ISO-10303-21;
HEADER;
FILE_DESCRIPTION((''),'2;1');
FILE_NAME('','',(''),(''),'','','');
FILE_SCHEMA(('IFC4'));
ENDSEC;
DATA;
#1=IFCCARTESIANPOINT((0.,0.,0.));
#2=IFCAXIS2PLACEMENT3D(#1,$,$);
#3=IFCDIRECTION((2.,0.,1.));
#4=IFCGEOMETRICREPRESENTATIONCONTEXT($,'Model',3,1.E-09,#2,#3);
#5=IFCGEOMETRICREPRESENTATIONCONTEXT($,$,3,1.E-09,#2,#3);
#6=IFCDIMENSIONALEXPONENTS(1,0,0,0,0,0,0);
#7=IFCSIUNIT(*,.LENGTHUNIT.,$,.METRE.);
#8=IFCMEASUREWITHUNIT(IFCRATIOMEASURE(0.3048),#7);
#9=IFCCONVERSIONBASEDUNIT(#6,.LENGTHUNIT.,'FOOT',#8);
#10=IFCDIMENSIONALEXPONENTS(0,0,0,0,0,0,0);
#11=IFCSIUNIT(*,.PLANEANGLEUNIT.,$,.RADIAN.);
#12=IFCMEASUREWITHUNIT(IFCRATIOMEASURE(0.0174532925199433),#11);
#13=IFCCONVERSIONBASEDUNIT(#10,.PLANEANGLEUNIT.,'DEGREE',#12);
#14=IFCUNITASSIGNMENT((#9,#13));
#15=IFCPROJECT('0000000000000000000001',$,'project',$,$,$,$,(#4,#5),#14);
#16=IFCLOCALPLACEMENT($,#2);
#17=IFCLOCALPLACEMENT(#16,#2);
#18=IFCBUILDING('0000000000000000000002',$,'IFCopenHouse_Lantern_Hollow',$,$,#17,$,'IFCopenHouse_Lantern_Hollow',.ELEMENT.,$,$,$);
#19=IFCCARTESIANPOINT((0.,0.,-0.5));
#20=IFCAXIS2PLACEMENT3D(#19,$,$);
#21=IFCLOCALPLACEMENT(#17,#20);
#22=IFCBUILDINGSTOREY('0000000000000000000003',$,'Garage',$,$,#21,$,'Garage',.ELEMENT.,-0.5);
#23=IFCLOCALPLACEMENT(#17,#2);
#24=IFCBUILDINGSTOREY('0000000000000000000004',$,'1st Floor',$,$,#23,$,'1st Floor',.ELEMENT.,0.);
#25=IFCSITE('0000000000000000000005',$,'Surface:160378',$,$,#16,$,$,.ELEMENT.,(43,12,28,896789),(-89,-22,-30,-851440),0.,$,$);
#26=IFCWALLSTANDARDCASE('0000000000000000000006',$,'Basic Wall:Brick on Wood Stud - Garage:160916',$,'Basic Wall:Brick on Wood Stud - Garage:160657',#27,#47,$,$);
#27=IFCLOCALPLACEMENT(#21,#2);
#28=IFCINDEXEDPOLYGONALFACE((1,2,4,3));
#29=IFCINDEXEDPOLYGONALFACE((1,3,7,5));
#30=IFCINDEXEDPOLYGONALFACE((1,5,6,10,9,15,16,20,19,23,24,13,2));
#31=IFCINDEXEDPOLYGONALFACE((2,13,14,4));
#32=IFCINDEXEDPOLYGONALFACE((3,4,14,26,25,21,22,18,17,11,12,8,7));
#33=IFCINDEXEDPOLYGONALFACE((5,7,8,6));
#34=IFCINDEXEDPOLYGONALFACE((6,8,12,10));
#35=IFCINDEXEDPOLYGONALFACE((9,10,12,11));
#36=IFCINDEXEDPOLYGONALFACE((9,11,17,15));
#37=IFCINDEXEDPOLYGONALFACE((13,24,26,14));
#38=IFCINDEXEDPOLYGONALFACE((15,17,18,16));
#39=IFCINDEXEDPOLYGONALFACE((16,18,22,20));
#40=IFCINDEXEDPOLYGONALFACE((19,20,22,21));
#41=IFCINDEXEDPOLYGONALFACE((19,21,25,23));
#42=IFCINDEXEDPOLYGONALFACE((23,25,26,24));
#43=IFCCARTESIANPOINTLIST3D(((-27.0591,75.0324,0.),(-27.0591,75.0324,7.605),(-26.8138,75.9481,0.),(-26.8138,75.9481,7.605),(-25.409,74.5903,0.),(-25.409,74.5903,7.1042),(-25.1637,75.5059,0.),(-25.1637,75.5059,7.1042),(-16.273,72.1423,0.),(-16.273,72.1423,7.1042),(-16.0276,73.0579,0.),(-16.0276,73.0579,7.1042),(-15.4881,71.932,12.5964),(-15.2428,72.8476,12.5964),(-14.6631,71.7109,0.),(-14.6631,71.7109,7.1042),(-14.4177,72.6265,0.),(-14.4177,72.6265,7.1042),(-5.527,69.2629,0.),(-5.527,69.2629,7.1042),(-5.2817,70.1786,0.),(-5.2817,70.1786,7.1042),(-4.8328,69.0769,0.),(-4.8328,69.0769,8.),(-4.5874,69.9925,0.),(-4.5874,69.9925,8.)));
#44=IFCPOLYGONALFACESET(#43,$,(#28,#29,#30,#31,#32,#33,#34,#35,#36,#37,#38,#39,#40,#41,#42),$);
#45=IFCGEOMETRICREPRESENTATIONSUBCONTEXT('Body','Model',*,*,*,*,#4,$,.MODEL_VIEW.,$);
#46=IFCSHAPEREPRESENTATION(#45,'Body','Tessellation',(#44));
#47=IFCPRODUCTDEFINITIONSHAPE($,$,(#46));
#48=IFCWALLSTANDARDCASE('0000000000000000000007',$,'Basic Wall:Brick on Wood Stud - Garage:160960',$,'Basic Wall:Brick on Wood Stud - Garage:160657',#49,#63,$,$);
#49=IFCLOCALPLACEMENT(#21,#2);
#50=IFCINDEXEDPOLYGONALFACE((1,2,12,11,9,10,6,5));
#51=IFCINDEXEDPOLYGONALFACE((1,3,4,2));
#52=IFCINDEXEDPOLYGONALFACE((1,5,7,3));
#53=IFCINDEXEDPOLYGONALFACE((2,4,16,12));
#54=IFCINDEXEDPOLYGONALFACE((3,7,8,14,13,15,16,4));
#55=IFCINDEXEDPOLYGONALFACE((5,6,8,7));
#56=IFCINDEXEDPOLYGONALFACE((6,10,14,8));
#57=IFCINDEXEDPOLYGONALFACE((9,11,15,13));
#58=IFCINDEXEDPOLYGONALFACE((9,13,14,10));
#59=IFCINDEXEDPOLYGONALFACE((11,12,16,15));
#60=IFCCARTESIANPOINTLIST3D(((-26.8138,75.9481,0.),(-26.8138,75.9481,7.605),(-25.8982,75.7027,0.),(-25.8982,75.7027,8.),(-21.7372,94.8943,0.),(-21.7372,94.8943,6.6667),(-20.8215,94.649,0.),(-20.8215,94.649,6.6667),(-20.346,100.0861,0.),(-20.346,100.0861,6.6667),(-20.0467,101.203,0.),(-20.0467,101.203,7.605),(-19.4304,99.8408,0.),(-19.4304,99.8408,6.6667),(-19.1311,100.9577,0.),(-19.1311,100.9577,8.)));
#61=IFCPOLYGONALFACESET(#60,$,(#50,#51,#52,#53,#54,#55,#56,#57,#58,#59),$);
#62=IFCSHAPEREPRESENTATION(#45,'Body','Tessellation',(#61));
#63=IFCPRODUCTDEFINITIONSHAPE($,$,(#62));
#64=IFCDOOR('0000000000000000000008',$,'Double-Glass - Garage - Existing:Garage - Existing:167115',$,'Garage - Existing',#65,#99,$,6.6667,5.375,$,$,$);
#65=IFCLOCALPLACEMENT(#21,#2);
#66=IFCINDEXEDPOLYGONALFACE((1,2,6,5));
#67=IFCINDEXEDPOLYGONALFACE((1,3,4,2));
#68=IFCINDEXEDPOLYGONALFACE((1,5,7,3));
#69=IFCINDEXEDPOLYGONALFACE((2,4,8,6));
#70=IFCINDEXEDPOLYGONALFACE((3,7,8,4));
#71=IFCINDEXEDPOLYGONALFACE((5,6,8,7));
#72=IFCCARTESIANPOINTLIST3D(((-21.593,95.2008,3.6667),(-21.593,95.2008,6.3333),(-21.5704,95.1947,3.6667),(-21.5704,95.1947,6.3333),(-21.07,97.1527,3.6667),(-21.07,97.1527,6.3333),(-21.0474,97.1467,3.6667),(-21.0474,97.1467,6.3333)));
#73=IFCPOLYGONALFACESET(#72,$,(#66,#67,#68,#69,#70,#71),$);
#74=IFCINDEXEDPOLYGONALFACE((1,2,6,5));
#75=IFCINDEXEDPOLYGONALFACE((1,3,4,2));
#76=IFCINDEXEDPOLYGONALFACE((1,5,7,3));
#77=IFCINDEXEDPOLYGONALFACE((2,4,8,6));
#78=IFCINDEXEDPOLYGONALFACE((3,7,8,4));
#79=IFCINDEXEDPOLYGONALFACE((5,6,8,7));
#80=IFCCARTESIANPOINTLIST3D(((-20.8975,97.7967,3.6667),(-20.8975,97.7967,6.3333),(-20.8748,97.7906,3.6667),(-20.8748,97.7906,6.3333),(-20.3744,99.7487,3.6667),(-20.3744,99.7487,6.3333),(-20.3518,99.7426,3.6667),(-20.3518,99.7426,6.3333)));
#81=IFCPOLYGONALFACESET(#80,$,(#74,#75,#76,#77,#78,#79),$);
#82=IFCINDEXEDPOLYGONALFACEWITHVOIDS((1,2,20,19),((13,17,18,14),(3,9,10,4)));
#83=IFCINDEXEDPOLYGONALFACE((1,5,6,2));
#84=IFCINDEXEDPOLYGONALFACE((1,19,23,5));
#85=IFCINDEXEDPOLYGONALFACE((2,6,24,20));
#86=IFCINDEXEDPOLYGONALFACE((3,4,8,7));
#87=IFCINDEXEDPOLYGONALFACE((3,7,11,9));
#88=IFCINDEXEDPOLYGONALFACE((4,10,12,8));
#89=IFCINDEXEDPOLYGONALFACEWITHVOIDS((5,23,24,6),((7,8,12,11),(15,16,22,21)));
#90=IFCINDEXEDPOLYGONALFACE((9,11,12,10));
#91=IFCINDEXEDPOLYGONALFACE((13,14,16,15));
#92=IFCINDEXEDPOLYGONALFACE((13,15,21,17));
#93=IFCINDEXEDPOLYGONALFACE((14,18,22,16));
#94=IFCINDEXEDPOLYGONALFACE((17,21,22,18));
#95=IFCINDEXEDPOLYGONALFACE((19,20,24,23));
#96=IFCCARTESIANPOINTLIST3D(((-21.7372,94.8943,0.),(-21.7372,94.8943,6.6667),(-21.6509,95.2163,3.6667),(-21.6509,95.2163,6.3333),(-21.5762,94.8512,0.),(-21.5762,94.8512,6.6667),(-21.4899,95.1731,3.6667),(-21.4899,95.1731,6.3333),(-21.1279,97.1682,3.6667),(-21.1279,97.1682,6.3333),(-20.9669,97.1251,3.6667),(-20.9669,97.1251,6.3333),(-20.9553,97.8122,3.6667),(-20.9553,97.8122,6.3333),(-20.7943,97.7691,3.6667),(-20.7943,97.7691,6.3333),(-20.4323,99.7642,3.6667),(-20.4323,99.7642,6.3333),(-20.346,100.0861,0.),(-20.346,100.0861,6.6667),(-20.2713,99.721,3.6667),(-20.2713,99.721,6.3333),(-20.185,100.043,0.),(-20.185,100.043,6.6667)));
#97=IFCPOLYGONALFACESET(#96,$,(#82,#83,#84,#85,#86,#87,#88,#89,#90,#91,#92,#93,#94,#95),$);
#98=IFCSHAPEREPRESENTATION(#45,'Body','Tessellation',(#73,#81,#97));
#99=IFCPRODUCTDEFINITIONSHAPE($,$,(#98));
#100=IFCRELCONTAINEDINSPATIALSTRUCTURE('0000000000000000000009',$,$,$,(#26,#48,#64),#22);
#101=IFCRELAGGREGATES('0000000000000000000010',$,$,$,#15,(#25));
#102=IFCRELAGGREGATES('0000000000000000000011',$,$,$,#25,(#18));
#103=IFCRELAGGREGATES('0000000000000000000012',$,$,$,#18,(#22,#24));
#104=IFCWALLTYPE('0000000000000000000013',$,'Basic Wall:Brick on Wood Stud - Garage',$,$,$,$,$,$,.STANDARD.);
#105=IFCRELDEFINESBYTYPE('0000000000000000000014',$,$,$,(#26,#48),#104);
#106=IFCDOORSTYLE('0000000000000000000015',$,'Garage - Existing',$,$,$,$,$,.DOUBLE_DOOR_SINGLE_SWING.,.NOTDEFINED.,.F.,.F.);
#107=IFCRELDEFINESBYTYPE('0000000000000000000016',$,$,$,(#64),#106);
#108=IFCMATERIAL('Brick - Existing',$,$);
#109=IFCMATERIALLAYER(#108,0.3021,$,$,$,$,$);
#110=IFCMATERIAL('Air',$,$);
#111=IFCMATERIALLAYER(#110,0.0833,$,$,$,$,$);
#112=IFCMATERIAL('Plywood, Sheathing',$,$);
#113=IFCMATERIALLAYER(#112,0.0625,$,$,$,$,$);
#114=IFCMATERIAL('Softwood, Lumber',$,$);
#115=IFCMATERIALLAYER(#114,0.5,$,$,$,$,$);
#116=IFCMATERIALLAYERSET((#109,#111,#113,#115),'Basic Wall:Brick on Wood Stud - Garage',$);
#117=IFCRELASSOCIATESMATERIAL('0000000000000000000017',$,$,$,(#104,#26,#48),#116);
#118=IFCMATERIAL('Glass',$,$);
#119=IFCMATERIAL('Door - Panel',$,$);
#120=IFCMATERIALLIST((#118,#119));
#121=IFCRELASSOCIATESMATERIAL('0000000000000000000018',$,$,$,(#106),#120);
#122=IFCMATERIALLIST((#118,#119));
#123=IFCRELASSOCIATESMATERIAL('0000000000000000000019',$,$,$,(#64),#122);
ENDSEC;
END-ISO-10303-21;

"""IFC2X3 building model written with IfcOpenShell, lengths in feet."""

from ifc_helpers import new_model, entity, si_unit, converted_unit, direction, frame, frame_2d, origin, origin_2d_with_axis, place, context, subcontext, project, spatial, polyline, rectangle, outline, extrude, clip, bounded_halfspace, source, transform, mapped, material, material_list, layer, layer_set, layer_usage, type_object, type_shapes, element, fill, save


model = new_model("IFC2X3")

# Units and contexts
model_context = context("Model", 3, precision=1e-09, world=origin(), true_north=direction((2.0, 0.0, 1.0)))
context_of_model = context(None, 3, precision=1e-09, world=origin(), true_north=direction((2.0, 0.0, 1.0)))
body_context = subcontext(model_context, "Body", "Model", "MODEL_VIEW")
ifc_project = project(units=[converted_unit("LENGTHUNIT", "FOOT", entity("IfcRatioMeasure", 0.3048), si_unit("LENGTHUNIT", "METRE"), dimensions=[1, 0, 0, 0, 0, 0, 0]), converted_unit("PLANEANGLEUNIT", "DEGREE", entity("IfcRatioMeasure", 0.0174532925199433), si_unit("PLANEANGLEUNIT", "RADIAN"), dimensions=[0, 0, 0, 0, 0, 0, 0])], contexts=[model_context, context_of_model])

# Site, building, storey
site_placement = place(None, origin())
site = spatial("IfcSite", under=ifc_project, at=site_placement, Name="Surface:160378", CompositionType="ELEMENT", RefLatitude=(43, 12, 28, 896789), RefLongitude=(-89, -22, -30, -851440), RefElevation=0.0)
building_placement = place(site_placement, origin())
building = spatial("IfcBuilding", under=site, at=building_placement, Name="IFCopenHouse_Lantern_Hollow", LongName="IFCopenHouse_Lantern_Hollow", CompositionType="ELEMENT")
storey_1_placement = place(building_placement, frame((0.0, 0.0, -0.5)))
storey_1 = spatial("IfcBuildingStorey", under=building, at=storey_1_placement, Name="Garage", LongName="Garage", CompositionType="ELEMENT", Elevation=-0.5)

# Shared definitions
ifc_material_1 = material(Name="Brick - Existing")
ifc_layer_1 = layer(ifc_material_1, 0.3021)
ifc_material_2 = material(Name="Air")
ifc_layer_2 = layer(ifc_material_2, 0.0833)
ifc_material_3 = material(Name="Plywood, Sheathing")
ifc_layer_3 = layer(ifc_material_3, 0.0625)
ifc_material_4 = material(Name="Softwood, Lumber")
ifc_layer_4 = layer(ifc_material_4, 0.5)
ifc_layer_set_1 = layer_set([ifc_layer_1, ifc_layer_2, ifc_layer_3, ifc_layer_4], Name="Basic Wall:Brick on Wood Stud - Garage")
wall_type = type_object("IfcWallType", Name="Basic Wall:Brick on Wood Stud - Garage", PredefinedType="STANDARD", material=ifc_layer_set_1)

# Shared definitions
storey_2_placement = place(building_placement, origin())
storey_2 = spatial("IfcBuildingStorey", under=building, at=storey_2_placement, Name="1st Floor", LongName="1st Floor", CompositionType="ELEMENT", Elevation=0.0)

# Shared definitions
ifc_material_5 = material(Name="Glass")

# Wall, openings
ifc_layer_usage_1 = layer_usage(ifc_layer_set_1, "AXIS2", "NEGATIVE", 0.474)
wall_1_placement = place(storey_1_placement, frame((-4.7101, 69.5347, 0.0), z_axis=(0.0, 0.0, 1.0), x_axis=(-0.965926, 0.258819, 0.0)))
wall_1 = element("IfcWallStandardCase", 1, at=wall_1_placement, inside=storey_1, type_object=wall_type, material=ifc_layer_usage_1, Name="Basic Wall:Brick on Wood Stud - Garage:160916", ObjectType="Basic Wall:Brick on Wood Stud - Garage:160657", context=body_context, shape_type="Clipping", body=[
    clip(clip(extrude(rectangle(XDim=23.0104, YDim=0.9479, at=frame_2d((11.5052, 0.0), x_axis=(-1.0, 0.0))), origin(), (0.0, 0.0, 1.0), 12.5964), bounded_halfspace(frame((0.0, 0.474, 8.0), z_axis=(-0.384615, 0.0, 0.923077), x_axis=(0.0, -1.0, 0.0)), False, frame((0.0, 0.474, 8.0)), polyline([(0.0, 0.0), (0.0, -0.9479), (11.0313, -0.9479), (11.0313, 0.0), (0.0, 0.0)]))), bounded_halfspace(frame((23.0104, -0.474, 7.605), z_axis=(0.384615, 0.0, 0.923077), x_axis=(0.0, 1.0, 0.0)), False, frame((23.0104, -0.474, 7.605)), polyline([(0.0, 0.0), (0.0, 0.9479), (-11.9792, 0.9479), (-11.9792, 0.0), (-0.9479, 0.0), (0.0, 0.0)]))),
])
opening_1_placement = place(wall_1_placement, frame((0.7188, -0.474, 0.0)))
element("IfcOpeningElement", 2, at=opening_1_placement, cuts=wall_1, ObjectType="Opening", context=body_context, shape_type="SweptSolid", body=[
    extrude(rectangle(XDim=7.1042, YDim=9.4583, at=frame_2d((3.5521, 4.7292), x_axis=(1.0, 0.0))), frame((0.0, 0.0, 0.0), z_axis=(0.0, 1.0, 0.0), x_axis=(0.0, 0.0, 1.0)), (0.0, 0.0, 1.0), 0.9479),
])
opening_2_placement = place(wall_1_placement, frame((11.8438, -0.474, 0.0)))
element("IfcOpeningElement", 3, at=opening_2_placement, cuts=wall_1, ObjectType="Opening", context=body_context, shape_type="SweptSolid", body=[
    extrude(rectangle(XDim=7.1042, YDim=9.4583, at=frame_2d((3.5521, 4.7292), x_axis=(1.0, 0.0))), frame((0.0, 0.0, 0.0), z_axis=(0.0, 1.0, 0.0), x_axis=(0.0, 0.0, 1.0)), (0.0, 0.0, 1.0), 0.9479),
])

# Wall, opening, door
ifc_layer_usage_2 = layer_usage(ifc_layer_set_1, "AXIS2", "NEGATIVE", 0.474)
wall_2_placement = place(storey_1_placement, frame((-26.356, 75.8254, 0.0), z_axis=(0.0, 0.0, 1.0), x_axis=(0.258819, 0.965926, 0.0)))
wall_2 = element("IfcWallStandardCase", 4, at=wall_2_placement, inside=storey_1, type_object=wall_type, material=ifc_layer_usage_2, Name="Basic Wall:Brick on Wood Stud - Garage:160960", ObjectType="Basic Wall:Brick on Wood Stud - Garage:160657", context=body_context, shape_type="Clipping", body=[
    clip(extrude(rectangle(XDim=26.1458, YDim=0.9479, at=frame_2d((13.0729, 0.0), x_axis=(-1.0, 0.0))), origin(), (0.0, 0.0, 1.0), 8.0), bounded_halfspace(frame((0.0, -0.474, 8.0), z_axis=(0.0, 0.384615, 0.923077), x_axis=(-1.0, 0.0, 0.0)), False, frame((0.0, -0.474, 8.0)), polyline([(0.0, 0.0), (26.1458, 0.0), (26.1458, 0.9479), (0.0, 0.9479), (0.0, 0.0)]))),
])
opening_3_placement = place(wall_2_placement, frame((19.6146, -0.474, 0.0)))
opening_3 = element("IfcOpeningElement", 5, at=opening_3_placement, cuts=wall_2, ObjectType="Opening", context=body_context, shape_type="SweptSolid", body=[
    extrude(rectangle(XDim=5.375, YDim=6.6667, at=frame_2d((3.3333, 2.6875), x_axis=(0.0, -1.0))), frame((0.0, 0.0, 0.0), z_axis=(0.0, 1.0, 0.0), x_axis=(0.0, 0.0, 1.0)), (0.0, 0.0, 1.0), 0.9479),
])
ifc_material_6 = material(Name="Door - Panel")
ifc_material_list_1 = material_list([ifc_material_5, ifc_material_6])
ifc_material_list_2 = material_list([ifc_material_5, ifc_material_6])
door_style = type_object("IfcDoorStyle", Name="Garage - Existing", ConstructionType="NOTDEFINED", OperationType="DOUBLE_DOOR_SINGLE_SWING", ParameterTakesPrecedence=False, Sizeable=False, material=ifc_material_list_2)
shared_shape_1 = source(origin(), body_context, "Body", "SweptSolid", [
    extrude(rectangle(XDim=2.0208, YDim=0.0234, at=frame_2d((0.0, 0.0), x_axis=(1.0, 0.0))), frame((1.3438, 0.8919, 3.6667)), (0.0, 0.0, 1.0), 2.6667),
    extrude(rectangle(XDim=2.0208, YDim=0.0234, at=origin_2d_with_axis()), frame((4.0312, 0.8919, 3.6667)), (0.0, 0.0, 1.0), 2.6667),
    extrude(outline(polyline([(-3.3333, -2.6875), (3.3333, -2.6875), (3.3333, 2.6875), (-3.3333, 2.6875), (-3.3333, -2.6875)]), holes=[polyline([(-3.0, 0.3333), (-3.0, 2.3542), (-0.3333, 2.3542), (-0.3333, 0.3333), (-3.0, 0.3333)]), polyline([(-3.0, -2.3542), (-3.0, -0.3333), (-0.3333, -0.3333), (-0.3333, -2.3542), (-3.0, -2.3542)])]), frame((2.6875, 0.9635, 3.3333), z_axis=(0.0, -1.0, 0.0), x_axis=(0.0, 0.0, -1.0)), (0.0, 0.0, 1.0), 0.1667),
])
type_shapes(door_style, [shared_shape_1])
door_placement = place(storey_1_placement, frame((-20.8064, 94.6449, 0.0), z_axis=(0.0, 0.0, 1.0), x_axis=(0.258819, 0.965926, 0.0)))
door = element("IfcDoor", 6, at=door_placement, inside=storey_1, type_object=door_style, material=ifc_material_list_1, Name="Double-Glass - Garage - Existing:Garage - Existing:167115", ObjectType="Garage - Existing", OverallHeight=6.6667, OverallWidth=5.375, context=body_context, shape_type="MappedRepresentation", body=[
    mapped(shared_shape_1, transform((0.0, 0.0, 0.0), scale=1.0)),
])
fill(opening_3, door)

save(model, "model.ifc")
